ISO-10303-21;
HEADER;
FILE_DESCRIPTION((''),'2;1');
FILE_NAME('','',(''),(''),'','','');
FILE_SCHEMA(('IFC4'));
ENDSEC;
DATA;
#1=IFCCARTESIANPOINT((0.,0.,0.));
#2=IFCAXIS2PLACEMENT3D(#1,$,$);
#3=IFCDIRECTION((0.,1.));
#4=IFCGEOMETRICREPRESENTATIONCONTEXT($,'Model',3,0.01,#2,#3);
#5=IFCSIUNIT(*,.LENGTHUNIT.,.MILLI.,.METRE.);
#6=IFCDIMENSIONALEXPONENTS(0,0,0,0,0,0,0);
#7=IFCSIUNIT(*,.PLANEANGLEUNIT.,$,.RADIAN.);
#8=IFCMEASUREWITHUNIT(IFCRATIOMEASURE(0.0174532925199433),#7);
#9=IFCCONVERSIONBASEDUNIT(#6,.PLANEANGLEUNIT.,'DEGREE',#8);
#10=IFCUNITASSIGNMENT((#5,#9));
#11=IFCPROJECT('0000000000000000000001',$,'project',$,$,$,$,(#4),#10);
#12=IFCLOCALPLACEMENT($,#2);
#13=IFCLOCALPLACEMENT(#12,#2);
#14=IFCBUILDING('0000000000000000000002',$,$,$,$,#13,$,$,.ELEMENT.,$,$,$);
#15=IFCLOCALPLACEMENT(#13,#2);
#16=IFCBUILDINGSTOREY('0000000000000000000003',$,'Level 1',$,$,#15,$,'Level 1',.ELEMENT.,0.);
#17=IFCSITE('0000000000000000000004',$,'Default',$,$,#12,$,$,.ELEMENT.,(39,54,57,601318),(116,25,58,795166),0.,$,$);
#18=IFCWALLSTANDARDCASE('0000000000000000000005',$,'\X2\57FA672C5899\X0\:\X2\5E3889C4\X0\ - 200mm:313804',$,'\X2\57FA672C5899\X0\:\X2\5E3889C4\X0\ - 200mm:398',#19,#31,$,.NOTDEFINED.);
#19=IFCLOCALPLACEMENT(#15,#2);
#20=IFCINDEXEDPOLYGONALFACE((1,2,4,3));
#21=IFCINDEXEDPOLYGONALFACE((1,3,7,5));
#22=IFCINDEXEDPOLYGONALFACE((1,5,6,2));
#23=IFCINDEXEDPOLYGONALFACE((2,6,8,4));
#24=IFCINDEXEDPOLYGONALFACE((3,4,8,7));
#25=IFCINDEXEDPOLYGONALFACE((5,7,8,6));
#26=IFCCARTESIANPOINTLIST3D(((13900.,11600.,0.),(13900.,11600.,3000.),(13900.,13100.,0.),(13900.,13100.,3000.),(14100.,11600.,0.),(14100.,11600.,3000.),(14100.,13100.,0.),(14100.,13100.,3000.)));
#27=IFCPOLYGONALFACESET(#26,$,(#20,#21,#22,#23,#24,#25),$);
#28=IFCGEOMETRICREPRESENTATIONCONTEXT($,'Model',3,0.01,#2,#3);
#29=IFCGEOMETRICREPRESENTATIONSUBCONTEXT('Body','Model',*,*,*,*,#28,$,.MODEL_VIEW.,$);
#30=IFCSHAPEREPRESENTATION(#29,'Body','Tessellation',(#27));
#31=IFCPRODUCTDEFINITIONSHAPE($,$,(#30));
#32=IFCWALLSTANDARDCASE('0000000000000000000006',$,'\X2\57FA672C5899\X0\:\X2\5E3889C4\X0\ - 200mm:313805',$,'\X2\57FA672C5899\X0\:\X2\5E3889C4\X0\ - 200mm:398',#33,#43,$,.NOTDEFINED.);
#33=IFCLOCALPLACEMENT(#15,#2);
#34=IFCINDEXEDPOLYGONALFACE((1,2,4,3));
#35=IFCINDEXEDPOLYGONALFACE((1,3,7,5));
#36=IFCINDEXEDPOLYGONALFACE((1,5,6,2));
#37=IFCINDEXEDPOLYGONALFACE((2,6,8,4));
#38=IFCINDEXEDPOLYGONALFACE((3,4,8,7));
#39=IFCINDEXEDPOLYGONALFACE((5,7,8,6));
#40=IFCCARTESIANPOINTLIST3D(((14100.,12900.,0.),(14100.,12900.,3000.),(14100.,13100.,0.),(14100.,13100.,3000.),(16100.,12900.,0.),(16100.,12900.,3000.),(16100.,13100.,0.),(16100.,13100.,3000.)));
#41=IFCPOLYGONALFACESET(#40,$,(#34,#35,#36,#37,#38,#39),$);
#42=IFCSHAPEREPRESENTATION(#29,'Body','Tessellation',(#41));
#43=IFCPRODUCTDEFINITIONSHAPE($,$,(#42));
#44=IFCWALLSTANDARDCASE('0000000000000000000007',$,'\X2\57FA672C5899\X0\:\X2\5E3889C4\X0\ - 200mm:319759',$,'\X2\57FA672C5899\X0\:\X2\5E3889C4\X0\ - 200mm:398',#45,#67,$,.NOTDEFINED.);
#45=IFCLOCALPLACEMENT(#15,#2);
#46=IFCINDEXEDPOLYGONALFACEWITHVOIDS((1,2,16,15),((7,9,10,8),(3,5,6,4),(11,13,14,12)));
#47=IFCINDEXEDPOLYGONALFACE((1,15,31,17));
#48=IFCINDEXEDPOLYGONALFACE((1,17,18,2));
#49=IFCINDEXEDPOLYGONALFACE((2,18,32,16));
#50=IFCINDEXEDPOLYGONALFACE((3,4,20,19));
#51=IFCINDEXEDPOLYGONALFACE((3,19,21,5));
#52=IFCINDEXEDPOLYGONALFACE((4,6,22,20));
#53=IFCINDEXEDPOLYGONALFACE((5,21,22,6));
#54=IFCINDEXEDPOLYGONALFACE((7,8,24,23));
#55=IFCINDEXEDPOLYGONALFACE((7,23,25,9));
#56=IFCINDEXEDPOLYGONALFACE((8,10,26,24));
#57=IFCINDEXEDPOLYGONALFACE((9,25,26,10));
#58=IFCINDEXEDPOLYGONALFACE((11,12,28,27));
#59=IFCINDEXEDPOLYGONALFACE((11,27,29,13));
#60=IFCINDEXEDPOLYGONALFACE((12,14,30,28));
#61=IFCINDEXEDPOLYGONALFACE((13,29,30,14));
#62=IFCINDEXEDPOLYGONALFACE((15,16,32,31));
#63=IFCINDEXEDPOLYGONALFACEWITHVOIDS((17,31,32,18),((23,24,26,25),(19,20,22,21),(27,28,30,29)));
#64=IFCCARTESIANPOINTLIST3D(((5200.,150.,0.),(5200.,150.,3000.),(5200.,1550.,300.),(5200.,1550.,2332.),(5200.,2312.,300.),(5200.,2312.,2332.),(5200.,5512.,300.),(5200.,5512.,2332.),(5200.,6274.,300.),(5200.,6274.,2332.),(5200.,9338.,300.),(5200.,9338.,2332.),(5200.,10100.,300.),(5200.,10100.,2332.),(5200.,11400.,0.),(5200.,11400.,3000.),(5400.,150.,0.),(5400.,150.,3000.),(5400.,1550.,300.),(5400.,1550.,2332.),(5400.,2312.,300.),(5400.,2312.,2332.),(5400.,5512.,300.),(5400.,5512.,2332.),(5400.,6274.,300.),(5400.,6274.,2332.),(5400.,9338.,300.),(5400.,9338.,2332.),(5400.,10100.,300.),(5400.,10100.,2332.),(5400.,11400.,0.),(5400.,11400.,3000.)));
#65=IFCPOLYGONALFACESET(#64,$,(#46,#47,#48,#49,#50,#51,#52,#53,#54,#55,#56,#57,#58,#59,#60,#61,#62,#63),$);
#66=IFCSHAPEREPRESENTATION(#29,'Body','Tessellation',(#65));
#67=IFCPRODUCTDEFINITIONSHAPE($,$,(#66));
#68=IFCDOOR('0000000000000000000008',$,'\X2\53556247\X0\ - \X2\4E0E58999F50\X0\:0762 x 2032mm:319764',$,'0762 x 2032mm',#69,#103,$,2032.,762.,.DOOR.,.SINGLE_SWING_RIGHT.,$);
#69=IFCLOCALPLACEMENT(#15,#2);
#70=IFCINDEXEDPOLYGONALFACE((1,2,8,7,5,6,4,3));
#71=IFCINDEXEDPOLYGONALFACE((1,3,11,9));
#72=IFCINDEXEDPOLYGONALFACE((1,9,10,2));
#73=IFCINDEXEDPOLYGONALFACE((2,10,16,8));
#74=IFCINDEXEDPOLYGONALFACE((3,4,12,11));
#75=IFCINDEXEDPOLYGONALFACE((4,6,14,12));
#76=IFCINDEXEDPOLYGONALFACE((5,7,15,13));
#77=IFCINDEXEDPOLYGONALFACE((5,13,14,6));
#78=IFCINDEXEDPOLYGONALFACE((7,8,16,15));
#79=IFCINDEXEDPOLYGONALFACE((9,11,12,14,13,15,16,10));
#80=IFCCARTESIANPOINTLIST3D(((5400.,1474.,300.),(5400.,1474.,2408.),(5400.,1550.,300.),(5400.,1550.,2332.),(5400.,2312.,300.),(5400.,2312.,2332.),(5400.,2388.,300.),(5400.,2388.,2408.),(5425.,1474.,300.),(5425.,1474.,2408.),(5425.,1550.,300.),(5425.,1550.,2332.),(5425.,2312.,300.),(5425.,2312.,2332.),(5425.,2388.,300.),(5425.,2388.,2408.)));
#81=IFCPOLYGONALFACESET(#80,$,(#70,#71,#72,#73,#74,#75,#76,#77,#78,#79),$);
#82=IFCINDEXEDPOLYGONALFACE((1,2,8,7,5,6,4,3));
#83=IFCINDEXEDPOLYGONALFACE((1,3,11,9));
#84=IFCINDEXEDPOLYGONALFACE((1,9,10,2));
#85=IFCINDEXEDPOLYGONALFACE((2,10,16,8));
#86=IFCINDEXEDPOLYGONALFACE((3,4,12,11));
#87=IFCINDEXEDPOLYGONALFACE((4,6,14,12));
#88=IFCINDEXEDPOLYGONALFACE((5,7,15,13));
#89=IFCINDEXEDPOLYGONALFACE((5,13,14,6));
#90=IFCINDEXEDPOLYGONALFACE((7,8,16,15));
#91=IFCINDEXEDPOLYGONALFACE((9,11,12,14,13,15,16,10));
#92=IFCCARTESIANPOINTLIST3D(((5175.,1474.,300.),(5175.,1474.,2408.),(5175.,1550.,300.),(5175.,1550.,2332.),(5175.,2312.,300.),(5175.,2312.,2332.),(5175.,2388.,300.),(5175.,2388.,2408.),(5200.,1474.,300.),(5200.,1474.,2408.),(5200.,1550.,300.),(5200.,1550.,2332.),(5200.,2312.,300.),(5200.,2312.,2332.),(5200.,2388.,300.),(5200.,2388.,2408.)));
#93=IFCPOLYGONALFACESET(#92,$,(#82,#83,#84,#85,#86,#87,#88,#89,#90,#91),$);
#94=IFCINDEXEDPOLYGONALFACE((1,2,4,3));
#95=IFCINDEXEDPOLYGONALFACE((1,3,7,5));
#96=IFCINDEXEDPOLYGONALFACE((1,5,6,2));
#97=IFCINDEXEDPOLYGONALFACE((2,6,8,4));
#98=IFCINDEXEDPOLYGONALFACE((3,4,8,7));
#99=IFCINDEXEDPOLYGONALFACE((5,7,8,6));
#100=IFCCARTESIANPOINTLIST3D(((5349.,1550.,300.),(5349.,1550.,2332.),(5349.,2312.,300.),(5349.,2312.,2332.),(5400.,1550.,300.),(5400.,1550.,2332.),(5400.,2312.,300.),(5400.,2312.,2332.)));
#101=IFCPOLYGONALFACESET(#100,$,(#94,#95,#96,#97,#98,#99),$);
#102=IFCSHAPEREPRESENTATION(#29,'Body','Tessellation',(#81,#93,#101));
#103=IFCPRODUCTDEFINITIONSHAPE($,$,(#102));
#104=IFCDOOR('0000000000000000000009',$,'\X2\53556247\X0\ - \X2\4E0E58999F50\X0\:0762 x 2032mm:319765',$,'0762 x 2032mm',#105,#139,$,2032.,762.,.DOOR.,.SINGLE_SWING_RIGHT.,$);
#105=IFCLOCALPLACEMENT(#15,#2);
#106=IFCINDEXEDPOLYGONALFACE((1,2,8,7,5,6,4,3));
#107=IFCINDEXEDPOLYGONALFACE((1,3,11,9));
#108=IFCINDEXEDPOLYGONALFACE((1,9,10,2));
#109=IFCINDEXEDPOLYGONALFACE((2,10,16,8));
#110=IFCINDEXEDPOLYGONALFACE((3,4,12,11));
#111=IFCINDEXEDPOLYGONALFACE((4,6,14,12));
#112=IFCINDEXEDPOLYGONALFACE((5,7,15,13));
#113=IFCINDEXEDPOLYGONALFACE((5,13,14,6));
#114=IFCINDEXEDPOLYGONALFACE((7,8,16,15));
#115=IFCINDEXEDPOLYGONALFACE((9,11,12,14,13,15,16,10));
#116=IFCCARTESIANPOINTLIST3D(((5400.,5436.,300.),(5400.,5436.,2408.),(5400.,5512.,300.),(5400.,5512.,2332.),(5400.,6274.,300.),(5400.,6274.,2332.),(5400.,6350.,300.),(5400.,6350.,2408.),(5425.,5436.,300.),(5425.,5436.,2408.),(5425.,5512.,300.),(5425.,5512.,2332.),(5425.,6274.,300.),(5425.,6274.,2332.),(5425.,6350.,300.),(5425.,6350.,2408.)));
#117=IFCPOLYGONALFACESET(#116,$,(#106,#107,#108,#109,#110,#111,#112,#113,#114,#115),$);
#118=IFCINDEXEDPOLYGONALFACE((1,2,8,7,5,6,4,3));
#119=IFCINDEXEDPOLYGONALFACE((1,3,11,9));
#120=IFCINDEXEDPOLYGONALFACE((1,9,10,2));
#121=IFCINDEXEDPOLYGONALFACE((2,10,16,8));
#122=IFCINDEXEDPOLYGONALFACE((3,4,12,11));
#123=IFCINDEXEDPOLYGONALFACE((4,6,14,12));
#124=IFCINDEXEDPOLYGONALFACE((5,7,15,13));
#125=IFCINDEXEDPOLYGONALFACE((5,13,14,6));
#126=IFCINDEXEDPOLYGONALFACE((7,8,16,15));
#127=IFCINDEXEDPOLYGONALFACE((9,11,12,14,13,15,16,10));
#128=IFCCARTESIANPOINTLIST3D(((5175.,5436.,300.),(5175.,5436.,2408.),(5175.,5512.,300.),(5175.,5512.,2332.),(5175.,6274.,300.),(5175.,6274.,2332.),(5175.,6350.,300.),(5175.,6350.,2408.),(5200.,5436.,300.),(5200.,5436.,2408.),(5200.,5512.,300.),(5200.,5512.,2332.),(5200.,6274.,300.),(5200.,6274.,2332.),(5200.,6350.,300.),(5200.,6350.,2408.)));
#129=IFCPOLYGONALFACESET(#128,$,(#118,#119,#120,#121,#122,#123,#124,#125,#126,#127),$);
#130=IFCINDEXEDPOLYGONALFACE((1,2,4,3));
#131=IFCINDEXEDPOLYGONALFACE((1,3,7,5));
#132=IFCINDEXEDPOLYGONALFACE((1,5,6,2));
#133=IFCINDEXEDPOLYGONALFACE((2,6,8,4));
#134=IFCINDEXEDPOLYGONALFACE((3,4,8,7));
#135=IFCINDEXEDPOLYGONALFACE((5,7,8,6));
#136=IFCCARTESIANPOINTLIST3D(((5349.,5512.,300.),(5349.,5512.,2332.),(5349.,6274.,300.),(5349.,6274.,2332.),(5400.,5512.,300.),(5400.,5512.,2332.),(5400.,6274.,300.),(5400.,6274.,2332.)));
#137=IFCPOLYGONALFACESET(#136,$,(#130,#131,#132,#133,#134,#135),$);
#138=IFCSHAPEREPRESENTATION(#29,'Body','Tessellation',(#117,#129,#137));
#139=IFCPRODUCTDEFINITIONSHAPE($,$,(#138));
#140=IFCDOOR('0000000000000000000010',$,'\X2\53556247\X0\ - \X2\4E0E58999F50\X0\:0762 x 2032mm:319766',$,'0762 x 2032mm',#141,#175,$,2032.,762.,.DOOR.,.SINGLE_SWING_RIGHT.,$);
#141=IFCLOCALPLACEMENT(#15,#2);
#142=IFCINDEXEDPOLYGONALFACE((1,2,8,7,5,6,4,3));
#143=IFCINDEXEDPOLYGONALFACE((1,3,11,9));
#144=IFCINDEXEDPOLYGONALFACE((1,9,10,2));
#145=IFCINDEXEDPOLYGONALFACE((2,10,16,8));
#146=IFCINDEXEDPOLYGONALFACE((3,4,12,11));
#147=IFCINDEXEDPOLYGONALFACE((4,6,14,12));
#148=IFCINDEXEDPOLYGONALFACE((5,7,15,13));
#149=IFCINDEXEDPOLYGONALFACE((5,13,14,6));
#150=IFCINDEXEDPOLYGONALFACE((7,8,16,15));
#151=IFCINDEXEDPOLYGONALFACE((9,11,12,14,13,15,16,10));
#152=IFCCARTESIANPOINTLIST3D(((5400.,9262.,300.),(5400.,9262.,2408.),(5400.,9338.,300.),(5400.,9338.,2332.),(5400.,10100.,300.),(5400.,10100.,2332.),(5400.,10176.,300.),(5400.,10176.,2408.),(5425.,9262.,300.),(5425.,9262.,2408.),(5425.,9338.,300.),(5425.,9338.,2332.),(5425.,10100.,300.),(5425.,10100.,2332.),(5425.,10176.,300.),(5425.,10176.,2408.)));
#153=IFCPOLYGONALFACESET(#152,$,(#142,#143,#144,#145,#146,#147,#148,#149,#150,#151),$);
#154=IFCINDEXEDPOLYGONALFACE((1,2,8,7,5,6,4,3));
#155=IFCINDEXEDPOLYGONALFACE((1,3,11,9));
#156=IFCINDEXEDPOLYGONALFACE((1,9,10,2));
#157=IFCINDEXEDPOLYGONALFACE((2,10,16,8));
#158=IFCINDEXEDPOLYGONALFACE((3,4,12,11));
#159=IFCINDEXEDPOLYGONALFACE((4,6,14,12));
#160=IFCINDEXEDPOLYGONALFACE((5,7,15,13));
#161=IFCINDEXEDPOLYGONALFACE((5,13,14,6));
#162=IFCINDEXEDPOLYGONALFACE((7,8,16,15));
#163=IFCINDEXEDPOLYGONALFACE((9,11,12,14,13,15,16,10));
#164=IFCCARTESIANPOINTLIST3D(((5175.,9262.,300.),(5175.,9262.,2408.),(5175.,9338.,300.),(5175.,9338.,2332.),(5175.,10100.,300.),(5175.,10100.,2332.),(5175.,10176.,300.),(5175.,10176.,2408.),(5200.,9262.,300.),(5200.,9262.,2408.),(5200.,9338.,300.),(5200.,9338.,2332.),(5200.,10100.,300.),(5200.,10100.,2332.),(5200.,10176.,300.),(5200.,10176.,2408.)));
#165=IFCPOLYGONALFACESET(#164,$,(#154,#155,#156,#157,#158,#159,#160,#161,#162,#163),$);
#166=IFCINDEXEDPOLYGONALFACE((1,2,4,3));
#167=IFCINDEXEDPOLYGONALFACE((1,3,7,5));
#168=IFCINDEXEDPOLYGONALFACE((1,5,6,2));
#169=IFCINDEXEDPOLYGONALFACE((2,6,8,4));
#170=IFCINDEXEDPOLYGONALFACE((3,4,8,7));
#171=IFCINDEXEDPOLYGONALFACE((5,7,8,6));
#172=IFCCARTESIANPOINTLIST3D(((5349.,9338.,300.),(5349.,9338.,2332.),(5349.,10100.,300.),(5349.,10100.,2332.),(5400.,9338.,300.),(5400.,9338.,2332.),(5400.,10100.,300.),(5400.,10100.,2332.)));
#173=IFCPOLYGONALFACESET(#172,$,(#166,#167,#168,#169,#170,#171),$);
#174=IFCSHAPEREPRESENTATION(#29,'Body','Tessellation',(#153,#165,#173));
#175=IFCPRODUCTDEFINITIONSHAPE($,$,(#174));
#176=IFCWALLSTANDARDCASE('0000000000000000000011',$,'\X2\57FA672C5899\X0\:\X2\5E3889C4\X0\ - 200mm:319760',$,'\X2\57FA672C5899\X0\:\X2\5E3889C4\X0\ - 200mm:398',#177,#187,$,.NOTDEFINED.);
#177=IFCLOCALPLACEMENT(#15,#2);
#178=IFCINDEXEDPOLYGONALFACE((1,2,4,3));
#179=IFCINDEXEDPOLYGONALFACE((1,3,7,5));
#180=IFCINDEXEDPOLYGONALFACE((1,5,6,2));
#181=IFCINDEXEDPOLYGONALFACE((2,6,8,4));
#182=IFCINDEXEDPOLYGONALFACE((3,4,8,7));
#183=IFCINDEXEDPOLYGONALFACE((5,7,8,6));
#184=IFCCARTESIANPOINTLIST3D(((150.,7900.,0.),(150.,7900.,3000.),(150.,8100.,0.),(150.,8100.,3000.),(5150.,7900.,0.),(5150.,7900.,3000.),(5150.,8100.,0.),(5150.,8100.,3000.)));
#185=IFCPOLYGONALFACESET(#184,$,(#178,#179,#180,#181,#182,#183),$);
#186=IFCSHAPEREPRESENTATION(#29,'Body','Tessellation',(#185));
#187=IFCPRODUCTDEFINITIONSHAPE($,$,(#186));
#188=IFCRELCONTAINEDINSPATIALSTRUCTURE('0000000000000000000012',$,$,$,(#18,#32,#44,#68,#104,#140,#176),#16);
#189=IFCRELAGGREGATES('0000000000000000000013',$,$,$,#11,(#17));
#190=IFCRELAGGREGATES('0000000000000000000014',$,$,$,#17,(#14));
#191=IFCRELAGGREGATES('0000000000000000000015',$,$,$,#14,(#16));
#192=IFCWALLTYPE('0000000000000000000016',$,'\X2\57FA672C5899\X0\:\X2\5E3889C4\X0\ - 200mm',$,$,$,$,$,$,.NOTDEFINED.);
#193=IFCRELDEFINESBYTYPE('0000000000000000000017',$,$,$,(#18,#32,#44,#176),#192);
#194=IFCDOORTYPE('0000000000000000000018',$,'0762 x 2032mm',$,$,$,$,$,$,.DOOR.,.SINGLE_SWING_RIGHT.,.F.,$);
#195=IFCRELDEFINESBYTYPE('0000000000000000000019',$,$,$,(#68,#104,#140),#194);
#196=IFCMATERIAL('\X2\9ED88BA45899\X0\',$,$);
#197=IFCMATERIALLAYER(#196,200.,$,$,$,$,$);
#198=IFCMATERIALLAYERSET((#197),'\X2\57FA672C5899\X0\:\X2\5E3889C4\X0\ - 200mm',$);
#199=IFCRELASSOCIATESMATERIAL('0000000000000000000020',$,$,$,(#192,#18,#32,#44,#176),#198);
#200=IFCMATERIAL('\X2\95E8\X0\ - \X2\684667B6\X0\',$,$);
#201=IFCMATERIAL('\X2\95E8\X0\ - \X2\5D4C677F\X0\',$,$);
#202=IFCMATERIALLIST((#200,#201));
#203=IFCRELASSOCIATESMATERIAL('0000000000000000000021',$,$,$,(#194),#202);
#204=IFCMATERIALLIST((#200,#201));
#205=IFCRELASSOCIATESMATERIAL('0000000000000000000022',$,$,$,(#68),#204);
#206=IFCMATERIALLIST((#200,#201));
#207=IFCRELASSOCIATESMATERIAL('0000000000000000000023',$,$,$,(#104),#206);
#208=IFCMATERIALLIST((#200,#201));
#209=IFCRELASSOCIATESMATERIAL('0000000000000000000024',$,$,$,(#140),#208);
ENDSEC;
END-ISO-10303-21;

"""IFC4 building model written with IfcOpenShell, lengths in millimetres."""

from ifc_helpers import new_model, entity, si_unit, converted_unit, direction, frame, frame_2d, origin, origin_2d_with_axis, place, context, subcontext, project, spatial, polyline, rectangle, outline, extrude, source, transform, mapped, material, material_list, layer, layer_set, layer_usage, type_object, type_shapes, element, fill, save


model = new_model("IFC4")

# Units and contexts
model_context_1 = context("Model", 3, precision=0.01, world=origin(), true_north=direction((0.0, 1.0)))
model_context_2 = context("Model", 3, precision=0.01, world=origin(), true_north=direction((0.0, 1.0)))
body_context = subcontext(model_context_2, "Body", "Model", "MODEL_VIEW")
ifc_project = project(units=[si_unit("LENGTHUNIT", "METRE", prefix="MILLI"), converted_unit("PLANEANGLEUNIT", "DEGREE", entity("IfcRatioMeasure", 0.0174532925199433), si_unit("PLANEANGLEUNIT", "RADIAN"), dimensions=[0, 0, 0, 0, 0, 0, 0])], contexts=[model_context_1])

# Site, building, storey
site_placement = place(None, origin())
site = spatial("IfcSite", under=ifc_project, at=site_placement, Name="Default", CompositionType="ELEMENT", RefLatitude=(39, 54, 57, 601318), RefLongitude=(116, 25, 58, 795166), RefElevation=0.0)
building_placement = place(site_placement, origin())
building = spatial("IfcBuilding", under=site, at=building_placement, CompositionType="ELEMENT")
storey_placement = place(building_placement, origin())
storey = spatial("IfcBuildingStorey", under=building, at=storey_placement, Name="Level 1", LongName="Level 1", CompositionType="ELEMENT", Elevation=0.0)

# Shared definitions
ifc_material_1 = material(Name="默认墙")
ifc_layer = layer(ifc_material_1, 200.0)
ifc_layer_set = layer_set([ifc_layer], Name="基本墙:常规 - 200mm")
wall_type = type_object("IfcWallType", Name="基本墙:常规 - 200mm", PredefinedType="NOTDEFINED", material=ifc_layer_set)

# Walls
ifc_layer_usage_1 = layer_usage(ifc_layer_set, "AXIS2", "NEGATIVE", 100.0)
wall_1_placement = place(storey_placement, frame((14000.0, 11600.0, 0.0), z_axis=(0.0, 0.0, 1.0), x_axis=(0.0, 1.0, 0.0)))
element("IfcWallStandardCase", 1, at=wall_1_placement, inside=storey, type_object=wall_type, material=ifc_layer_usage_1, Name="基本墙:常规 - 200mm:313804", ObjectType="基本墙:常规 - 200mm:398", PredefinedType="NOTDEFINED", context=body_context, shape_type="SweptSolid", body=[
    extrude(rectangle(XDim=1500.0, YDim=200.0, at=frame_2d((750.0, 0.0), x_axis=(-1.0, 0.0))), origin(), (0.0, 0.0, 1.0), 3000.0),
])
ifc_layer_usage_2 = layer_usage(ifc_layer_set, "AXIS2", "NEGATIVE", 100.0)
wall_2_placement = place(storey_placement, frame((14100.0, 13000.0, 0.0)))
element("IfcWallStandardCase", 2, at=wall_2_placement, inside=storey, type_object=wall_type, material=ifc_layer_usage_2, Name="基本墙:常规 - 200mm:313805", ObjectType="基本墙:常规 - 200mm:398", PredefinedType="NOTDEFINED", context=body_context, shape_type="SweptSolid", body=[
    extrude(rectangle(XDim=2000.0, YDim=200.0, at=frame_2d((1000.0, 0.0), x_axis=(-1.0, 0.0))), origin(), (0.0, 0.0, 1.0), 3000.0),
])

# Wall, openings, doors
ifc_layer_usage_3 = layer_usage(ifc_layer_set, "AXIS2", "NEGATIVE", 100.0)
wall_3_placement = place(storey_placement, frame((5300.0, 11400.0, 0.0), z_axis=(0.0, 0.0, 1.0), x_axis=(0.0, -1.0, 0.0)))
wall_3 = element("IfcWallStandardCase", 3, at=wall_3_placement, inside=storey, type_object=wall_type, material=ifc_layer_usage_3, Name="基本墙:常规 - 200mm:319759", ObjectType="基本墙:常规 - 200mm:398", PredefinedType="NOTDEFINED", context=body_context, shape_type="SweptSolid", body=[
    extrude(rectangle(XDim=11250.0, YDim=200.0, at=frame_2d((5625.0, 0.0), x_axis=(-1.0, 0.0))), origin(), (0.0, 0.0, 1.0), 3000.0),
])
opening_1_placement = place(wall_3_placement, frame((9088.0, -100.0, 300.0)))
opening_1 = element("IfcOpeningElement", 4, at=opening_1_placement, cuts=wall_3, ObjectType="Opening", PredefinedType="OPENING", context=body_context, shape_type="SweptSolid", body=[
    extrude(rectangle(XDim=762.0, YDim=2032.0, at=frame_2d((1016.0, 381.0), x_axis=(0.0, 1.0))), frame((0.0, 0.0, 0.0), z_axis=(0.0, 1.0, 0.0), x_axis=(0.0, 0.0, 1.0)), (0.0, 0.0, 1.0), 200.0),
])
opening_2_placement = place(wall_3_placement, frame((5126.0, -100.0, 300.0)))
opening_2 = element("IfcOpeningElement", 5, at=opening_2_placement, cuts=wall_3, ObjectType="Opening", PredefinedType="OPENING", context=body_context, shape_type="SweptSolid", body=[
    extrude(rectangle(XDim=762.0, YDim=2032.0, at=frame_2d((1016.0, 381.0), x_axis=(0.0, 1.0))), frame((0.0, 0.0, 0.0), z_axis=(0.0, 1.0, 0.0), x_axis=(0.0, 0.0, 1.0)), (0.0, 0.0, 1.0), 200.0),
])
opening_3_placement = place(wall_3_placement, frame((1300.0, -100.0, 300.0)))
opening_3 = element("IfcOpeningElement", 6, at=opening_3_placement, cuts=wall_3, ObjectType="Opening", PredefinedType="OPENING", context=body_context, shape_type="SweptSolid", body=[
    extrude(rectangle(XDim=762.0, YDim=2032.0, at=frame_2d((1016.0, 381.0), x_axis=(0.0, 1.0))), frame((0.0, 0.0, 0.0), z_axis=(0.0, 1.0, 0.0), x_axis=(0.0, 0.0, 1.0)), (0.0, 0.0, 1.0), 200.0),
])
ifc_material_2 = material(Name="门 - 框架")
ifc_material_3 = material(Name="门 - 嵌板")
ifc_material_list_1 = material_list([ifc_material_2, ifc_material_3])
ifc_material_list_2 = material_list([ifc_material_2, ifc_material_3])
door_type_1 = type_object("IfcDoorType", Name="0762 x 2032mm", OperationType="SINGLE_SWING_RIGHT", ParameterTakesPrecedence=False, PredefinedType="DOOR", material=ifc_material_list_2)
shared_shape_1 = source(origin(), body_context, "Body", "SweptSolid", [
    extrude(outline(polyline([(-457.0, -1073.0), (457.0, -1073.0), (457.0, 1035.0), (381.0, 1035.0), (381.0, -997.0), (-381.0, -997.0), (-381.0, 1035.0), (-457.0, 1035.0), (-457.0, -1073.0)])), frame((381.0, 200.0, 1035.0), z_axis=(0.0, 1.0, 0.0), x_axis=(1.0, 0.0, 0.0)), (0.0, 0.0, 1.0), 25.0),
    extrude(outline(polyline([(-1073.0, -457.0), (1035.0, -457.0), (1035.0, -381.0), (-997.0, -381.0), (-997.0, 381.0), (1035.0, 381.0), (1035.0, 457.0), (-1073.0, 457.0), (-1073.0, -457.0)])), frame((381.0, -25.0, 1035.0), z_axis=(0.0, 1.0, 0.0), x_axis=(0.0, 0.0, -1.0)), (0.0, 0.0, 1.0), 25.0),
    extrude(rectangle(XDim=51.0, YDim=762.0, at=origin_2d_with_axis()), frame((381.0, 174.5, 0.0), z_axis=(0.0, 0.0, 1.0), x_axis=(0.0, 1.0, 0.0)), (0.0, 0.0, 1.0), 2032.0),
])
type_shapes(door_type_1, [shared_shape_1])
door_1_placement = place(opening_1_placement, origin())
door_1 = element("IfcDoor", 7, at=door_1_placement, inside=storey, type_object=door_type_1, material=ifc_material_list_1, Name="单扇 - 与墙齐:0762 x 2032mm:319764", ObjectType="0762 x 2032mm", OperationType="SINGLE_SWING_RIGHT", OverallHeight=2032.0, OverallWidth=762.0, PredefinedType="DOOR", context=body_context, shape_type="MappedRepresentation", body=[
    mapped(shared_shape_1, transform((0.0, 0.0, 0.0), scale=1.0)),
])
fill(opening_1, door_1)
ifc_material_list_3 = material_list([ifc_material_2, ifc_material_3])
door_2_placement = place(opening_2_placement, origin())
door_2 = element("IfcDoor", 8, at=door_2_placement, inside=storey, type_object=door_type_1, material=ifc_material_list_3, Name="单扇 - 与墙齐:0762 x 2032mm:319765", ObjectType="0762 x 2032mm", OperationType="SINGLE_SWING_RIGHT", OverallHeight=2032.0, OverallWidth=762.0, PredefinedType="DOOR", context=body_context, shape_type="MappedRepresentation", body=[
    mapped(shared_shape_1, transform((0.0, 0.0, 0.0), scale=1.0)),
])
fill(opening_2, door_2)
ifc_material_list_4 = material_list([ifc_material_2, ifc_material_3])
door_3_placement = place(opening_3_placement, origin())
door_3 = element("IfcDoor", 9, at=door_3_placement, inside=storey, type_object=door_type_1, material=ifc_material_list_4, Name="单扇 - 与墙齐:0762 x 2032mm:319766", ObjectType="0762 x 2032mm", OperationType="SINGLE_SWING_RIGHT", OverallHeight=2032.0, OverallWidth=762.0, PredefinedType="DOOR", context=body_context, shape_type="MappedRepresentation", body=[
    mapped(shared_shape_1, transform((0.0, 0.0, 0.0), scale=1.0)),
])
fill(opening_3, door_3)

# Wall
ifc_layer_usage_4 = layer_usage(ifc_layer_set, "AXIS2", "NEGATIVE", 100.0)
wall_4_placement = place(storey_placement, frame((150.0, 8000.0, 0.0)))
element("IfcWallStandardCase", 10, at=wall_4_placement, inside=storey, type_object=wall_type, material=ifc_layer_usage_4, Name="基本墙:常规 - 200mm:319760", ObjectType="基本墙:常规 - 200mm:398", PredefinedType="NOTDEFINED", context=body_context, shape_type="SweptSolid", body=[
    extrude(rectangle(XDim=5000.0, YDim=200.0, at=frame_2d((2500.0, 0.0), x_axis=(-1.0, 0.0))), origin(), (0.0, 0.0, 1.0), 3000.0),
])

save(model, "model.ifc")
